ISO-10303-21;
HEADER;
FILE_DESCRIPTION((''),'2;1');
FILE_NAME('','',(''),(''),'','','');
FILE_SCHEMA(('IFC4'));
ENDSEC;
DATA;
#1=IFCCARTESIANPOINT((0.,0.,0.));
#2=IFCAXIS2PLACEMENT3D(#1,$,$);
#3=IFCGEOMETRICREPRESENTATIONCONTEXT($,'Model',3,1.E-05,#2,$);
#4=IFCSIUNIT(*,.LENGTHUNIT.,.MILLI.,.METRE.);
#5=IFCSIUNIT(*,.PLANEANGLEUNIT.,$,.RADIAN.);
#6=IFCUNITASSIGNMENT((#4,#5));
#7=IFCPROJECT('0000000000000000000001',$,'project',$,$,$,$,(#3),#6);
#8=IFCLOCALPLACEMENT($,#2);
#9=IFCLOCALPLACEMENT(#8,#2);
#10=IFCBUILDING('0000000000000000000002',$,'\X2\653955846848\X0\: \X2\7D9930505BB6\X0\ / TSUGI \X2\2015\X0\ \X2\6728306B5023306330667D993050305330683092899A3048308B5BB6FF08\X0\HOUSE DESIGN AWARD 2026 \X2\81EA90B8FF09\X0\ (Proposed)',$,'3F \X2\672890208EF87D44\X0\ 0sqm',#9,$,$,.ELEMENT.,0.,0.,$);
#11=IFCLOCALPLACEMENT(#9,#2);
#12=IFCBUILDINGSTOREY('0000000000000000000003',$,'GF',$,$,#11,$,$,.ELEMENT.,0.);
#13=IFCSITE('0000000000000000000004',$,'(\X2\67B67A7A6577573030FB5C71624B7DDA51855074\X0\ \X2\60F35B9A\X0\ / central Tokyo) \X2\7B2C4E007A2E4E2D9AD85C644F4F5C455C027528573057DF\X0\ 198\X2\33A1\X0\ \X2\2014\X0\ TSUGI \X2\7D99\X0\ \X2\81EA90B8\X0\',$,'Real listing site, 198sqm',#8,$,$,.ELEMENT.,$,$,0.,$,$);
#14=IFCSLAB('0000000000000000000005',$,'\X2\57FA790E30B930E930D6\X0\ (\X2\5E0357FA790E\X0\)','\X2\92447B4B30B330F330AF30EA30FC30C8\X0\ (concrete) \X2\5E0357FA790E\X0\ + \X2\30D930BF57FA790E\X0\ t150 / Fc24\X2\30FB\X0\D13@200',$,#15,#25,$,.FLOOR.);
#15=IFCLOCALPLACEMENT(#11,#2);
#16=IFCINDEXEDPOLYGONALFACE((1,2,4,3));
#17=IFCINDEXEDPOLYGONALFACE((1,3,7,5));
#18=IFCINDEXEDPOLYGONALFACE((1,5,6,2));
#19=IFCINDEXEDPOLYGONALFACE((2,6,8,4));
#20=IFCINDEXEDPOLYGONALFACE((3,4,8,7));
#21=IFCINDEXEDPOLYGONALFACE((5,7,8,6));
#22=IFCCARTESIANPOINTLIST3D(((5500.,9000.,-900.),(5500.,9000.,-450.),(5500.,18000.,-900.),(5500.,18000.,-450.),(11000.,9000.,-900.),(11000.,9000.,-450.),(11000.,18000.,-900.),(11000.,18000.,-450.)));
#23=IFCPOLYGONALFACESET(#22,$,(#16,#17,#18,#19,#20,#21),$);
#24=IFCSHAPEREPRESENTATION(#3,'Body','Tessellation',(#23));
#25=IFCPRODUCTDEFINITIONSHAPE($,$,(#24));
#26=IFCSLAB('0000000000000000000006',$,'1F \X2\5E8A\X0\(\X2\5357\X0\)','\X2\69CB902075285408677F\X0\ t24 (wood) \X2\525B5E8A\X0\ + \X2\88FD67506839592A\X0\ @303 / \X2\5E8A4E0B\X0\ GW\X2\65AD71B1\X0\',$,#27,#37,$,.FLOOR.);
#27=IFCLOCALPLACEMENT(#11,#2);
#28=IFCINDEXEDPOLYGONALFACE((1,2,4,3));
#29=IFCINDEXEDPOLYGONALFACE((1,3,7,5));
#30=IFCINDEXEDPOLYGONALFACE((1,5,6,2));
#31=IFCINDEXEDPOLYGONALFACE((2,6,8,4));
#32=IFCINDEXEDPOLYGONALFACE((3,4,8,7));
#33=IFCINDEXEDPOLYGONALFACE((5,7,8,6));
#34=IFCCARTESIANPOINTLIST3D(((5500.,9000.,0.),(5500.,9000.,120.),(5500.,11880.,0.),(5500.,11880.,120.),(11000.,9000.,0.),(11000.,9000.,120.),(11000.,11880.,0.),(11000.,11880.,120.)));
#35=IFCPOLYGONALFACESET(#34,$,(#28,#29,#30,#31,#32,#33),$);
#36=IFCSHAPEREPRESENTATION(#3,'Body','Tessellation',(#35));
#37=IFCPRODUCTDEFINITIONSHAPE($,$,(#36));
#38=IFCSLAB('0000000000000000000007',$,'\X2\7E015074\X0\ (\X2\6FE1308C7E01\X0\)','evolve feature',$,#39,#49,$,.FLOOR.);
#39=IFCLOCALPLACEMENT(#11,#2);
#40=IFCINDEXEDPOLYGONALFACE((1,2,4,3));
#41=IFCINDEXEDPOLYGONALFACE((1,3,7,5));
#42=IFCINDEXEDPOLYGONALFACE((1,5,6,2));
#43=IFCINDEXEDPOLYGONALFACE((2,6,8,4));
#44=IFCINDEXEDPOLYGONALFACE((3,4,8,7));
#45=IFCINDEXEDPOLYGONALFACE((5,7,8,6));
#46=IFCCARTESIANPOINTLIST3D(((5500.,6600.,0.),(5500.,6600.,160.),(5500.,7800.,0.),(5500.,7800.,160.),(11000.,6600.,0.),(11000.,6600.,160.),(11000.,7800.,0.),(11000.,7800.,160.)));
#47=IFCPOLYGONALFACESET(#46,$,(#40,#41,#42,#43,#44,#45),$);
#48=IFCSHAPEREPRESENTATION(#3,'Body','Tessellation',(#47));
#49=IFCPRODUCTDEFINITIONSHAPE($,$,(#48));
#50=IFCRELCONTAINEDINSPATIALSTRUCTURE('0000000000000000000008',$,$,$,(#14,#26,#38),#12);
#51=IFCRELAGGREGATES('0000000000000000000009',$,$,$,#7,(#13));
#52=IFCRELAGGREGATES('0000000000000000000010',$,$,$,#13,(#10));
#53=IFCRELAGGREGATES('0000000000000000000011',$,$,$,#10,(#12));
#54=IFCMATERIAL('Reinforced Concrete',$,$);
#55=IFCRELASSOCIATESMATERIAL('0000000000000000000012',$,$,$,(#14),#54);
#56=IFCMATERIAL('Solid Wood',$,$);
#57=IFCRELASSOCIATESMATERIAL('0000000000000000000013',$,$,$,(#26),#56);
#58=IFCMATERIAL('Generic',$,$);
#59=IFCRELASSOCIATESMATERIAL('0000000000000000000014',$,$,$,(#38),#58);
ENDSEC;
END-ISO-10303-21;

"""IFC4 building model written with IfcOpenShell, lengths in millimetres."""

from ifc_helpers import new_model, si_unit, frame, frame_2d, origin, place, context, project, spatial, rectangle, extrude, material, element, save


model = new_model("IFC4")

# Units and contexts
model_context = context("Model", 3, precision=1e-05, world=origin())
ifc_project = project(units=[si_unit("LENGTHUNIT", "METRE", prefix="MILLI"), si_unit("PLANEANGLEUNIT", "RADIAN")], contexts=[model_context])

# Site, building, storey
site_placement = place(None, origin())
site = spatial("IfcSite", under=ifc_project, at=site_placement, Name="(架空敷地・山手線内側 想定 / central Tokyo) 第一種中高層住居専用地域 198㎡ — TSUGI 継 自邸", ObjectType="Real listing site, 198sqm", CompositionType="ELEMENT", RefElevation=0.0)
building_placement = place(site_placement, origin())
building = spatial("IfcBuilding", under=site, at=building_placement, Name="改善案: 継ぐ家 / TSUGI ― 木に倣って継ぐことを覚える家（HOUSE DESIGN AWARD 2026 自邸） (Proposed)", ObjectType="3F 木造軸組 0sqm", CompositionType="ELEMENT", ElevationOfRefHeight=0.0, ElevationOfTerrain=0.0)
storey_placement = place(building_placement, origin())
storey = spatial("IfcBuildingStorey", under=building, at=storey_placement, Name="GF", CompositionType="ELEMENT", Elevation=0.0)

# Slabs
ifc_material_1 = material(Name="Reinforced Concrete")
slab_1_placement = place(storey_placement, frame((2750.0, 4500.0, -450.0)))
element("IfcSlab", 1, at=slab_1_placement, inside=storey, material=ifc_material_1, Name="基礎スラブ (布基礎)", Description="鉄筋コンクリート (concrete) 布基礎 + ベタ基礎 t150 / Fc24・D13@200", PredefinedType="FLOOR", context=model_context, shape_type="SweptSolid", body=[
    extrude(rectangle(XDim=5500.0, YDim=9000.0, at=frame_2d((2750.0, 4500.0))), frame((2750.0, 4500.0, -450.0)), (0.0, 0.0, 1.0), 450.0),
])
ifc_material_2 = material(Name="Solid Wood")
slab_2_placement = place(storey_placement, frame((2750.0, 4500.0, 0.0)))
element("IfcSlab", 2, at=slab_2_placement, inside=storey, material=ifc_material_2, Name="1F 床(南)", Description="構造用合板 t24 (wood) 剛床 + 製材根太 @303 / 床下 GW断熱", PredefinedType="FLOOR", context=model_context, shape_type="SweptSolid", body=[
    extrude(rectangle(XDim=5500.0, YDim=2880.0, at=frame_2d((2750.0, 1440.0))), frame((2750.0, 4500.0, 0.0)), (0.0, 0.0, 1.0), 120.0),
])
ifc_material_3 = material(Name="Generic")
slab_3_placement = place(storey_placement, frame((2750.0, 3300.0, 0.0)))
element("IfcSlab", 3, at=slab_3_placement, inside=storey, material=ifc_material_3, Name="縁側 (濡れ縁)", Description="evolve feature", PredefinedType="FLOOR", context=model_context, shape_type="SweptSolid", body=[
    extrude(rectangle(XDim=5500.0, YDim=1200.0, at=frame_2d((2750.0, 600.0))), frame((2750.0, 3300.0, 0.0)), (0.0, 0.0, 1.0), 160.0),
])

save(model, "model.ifc")
